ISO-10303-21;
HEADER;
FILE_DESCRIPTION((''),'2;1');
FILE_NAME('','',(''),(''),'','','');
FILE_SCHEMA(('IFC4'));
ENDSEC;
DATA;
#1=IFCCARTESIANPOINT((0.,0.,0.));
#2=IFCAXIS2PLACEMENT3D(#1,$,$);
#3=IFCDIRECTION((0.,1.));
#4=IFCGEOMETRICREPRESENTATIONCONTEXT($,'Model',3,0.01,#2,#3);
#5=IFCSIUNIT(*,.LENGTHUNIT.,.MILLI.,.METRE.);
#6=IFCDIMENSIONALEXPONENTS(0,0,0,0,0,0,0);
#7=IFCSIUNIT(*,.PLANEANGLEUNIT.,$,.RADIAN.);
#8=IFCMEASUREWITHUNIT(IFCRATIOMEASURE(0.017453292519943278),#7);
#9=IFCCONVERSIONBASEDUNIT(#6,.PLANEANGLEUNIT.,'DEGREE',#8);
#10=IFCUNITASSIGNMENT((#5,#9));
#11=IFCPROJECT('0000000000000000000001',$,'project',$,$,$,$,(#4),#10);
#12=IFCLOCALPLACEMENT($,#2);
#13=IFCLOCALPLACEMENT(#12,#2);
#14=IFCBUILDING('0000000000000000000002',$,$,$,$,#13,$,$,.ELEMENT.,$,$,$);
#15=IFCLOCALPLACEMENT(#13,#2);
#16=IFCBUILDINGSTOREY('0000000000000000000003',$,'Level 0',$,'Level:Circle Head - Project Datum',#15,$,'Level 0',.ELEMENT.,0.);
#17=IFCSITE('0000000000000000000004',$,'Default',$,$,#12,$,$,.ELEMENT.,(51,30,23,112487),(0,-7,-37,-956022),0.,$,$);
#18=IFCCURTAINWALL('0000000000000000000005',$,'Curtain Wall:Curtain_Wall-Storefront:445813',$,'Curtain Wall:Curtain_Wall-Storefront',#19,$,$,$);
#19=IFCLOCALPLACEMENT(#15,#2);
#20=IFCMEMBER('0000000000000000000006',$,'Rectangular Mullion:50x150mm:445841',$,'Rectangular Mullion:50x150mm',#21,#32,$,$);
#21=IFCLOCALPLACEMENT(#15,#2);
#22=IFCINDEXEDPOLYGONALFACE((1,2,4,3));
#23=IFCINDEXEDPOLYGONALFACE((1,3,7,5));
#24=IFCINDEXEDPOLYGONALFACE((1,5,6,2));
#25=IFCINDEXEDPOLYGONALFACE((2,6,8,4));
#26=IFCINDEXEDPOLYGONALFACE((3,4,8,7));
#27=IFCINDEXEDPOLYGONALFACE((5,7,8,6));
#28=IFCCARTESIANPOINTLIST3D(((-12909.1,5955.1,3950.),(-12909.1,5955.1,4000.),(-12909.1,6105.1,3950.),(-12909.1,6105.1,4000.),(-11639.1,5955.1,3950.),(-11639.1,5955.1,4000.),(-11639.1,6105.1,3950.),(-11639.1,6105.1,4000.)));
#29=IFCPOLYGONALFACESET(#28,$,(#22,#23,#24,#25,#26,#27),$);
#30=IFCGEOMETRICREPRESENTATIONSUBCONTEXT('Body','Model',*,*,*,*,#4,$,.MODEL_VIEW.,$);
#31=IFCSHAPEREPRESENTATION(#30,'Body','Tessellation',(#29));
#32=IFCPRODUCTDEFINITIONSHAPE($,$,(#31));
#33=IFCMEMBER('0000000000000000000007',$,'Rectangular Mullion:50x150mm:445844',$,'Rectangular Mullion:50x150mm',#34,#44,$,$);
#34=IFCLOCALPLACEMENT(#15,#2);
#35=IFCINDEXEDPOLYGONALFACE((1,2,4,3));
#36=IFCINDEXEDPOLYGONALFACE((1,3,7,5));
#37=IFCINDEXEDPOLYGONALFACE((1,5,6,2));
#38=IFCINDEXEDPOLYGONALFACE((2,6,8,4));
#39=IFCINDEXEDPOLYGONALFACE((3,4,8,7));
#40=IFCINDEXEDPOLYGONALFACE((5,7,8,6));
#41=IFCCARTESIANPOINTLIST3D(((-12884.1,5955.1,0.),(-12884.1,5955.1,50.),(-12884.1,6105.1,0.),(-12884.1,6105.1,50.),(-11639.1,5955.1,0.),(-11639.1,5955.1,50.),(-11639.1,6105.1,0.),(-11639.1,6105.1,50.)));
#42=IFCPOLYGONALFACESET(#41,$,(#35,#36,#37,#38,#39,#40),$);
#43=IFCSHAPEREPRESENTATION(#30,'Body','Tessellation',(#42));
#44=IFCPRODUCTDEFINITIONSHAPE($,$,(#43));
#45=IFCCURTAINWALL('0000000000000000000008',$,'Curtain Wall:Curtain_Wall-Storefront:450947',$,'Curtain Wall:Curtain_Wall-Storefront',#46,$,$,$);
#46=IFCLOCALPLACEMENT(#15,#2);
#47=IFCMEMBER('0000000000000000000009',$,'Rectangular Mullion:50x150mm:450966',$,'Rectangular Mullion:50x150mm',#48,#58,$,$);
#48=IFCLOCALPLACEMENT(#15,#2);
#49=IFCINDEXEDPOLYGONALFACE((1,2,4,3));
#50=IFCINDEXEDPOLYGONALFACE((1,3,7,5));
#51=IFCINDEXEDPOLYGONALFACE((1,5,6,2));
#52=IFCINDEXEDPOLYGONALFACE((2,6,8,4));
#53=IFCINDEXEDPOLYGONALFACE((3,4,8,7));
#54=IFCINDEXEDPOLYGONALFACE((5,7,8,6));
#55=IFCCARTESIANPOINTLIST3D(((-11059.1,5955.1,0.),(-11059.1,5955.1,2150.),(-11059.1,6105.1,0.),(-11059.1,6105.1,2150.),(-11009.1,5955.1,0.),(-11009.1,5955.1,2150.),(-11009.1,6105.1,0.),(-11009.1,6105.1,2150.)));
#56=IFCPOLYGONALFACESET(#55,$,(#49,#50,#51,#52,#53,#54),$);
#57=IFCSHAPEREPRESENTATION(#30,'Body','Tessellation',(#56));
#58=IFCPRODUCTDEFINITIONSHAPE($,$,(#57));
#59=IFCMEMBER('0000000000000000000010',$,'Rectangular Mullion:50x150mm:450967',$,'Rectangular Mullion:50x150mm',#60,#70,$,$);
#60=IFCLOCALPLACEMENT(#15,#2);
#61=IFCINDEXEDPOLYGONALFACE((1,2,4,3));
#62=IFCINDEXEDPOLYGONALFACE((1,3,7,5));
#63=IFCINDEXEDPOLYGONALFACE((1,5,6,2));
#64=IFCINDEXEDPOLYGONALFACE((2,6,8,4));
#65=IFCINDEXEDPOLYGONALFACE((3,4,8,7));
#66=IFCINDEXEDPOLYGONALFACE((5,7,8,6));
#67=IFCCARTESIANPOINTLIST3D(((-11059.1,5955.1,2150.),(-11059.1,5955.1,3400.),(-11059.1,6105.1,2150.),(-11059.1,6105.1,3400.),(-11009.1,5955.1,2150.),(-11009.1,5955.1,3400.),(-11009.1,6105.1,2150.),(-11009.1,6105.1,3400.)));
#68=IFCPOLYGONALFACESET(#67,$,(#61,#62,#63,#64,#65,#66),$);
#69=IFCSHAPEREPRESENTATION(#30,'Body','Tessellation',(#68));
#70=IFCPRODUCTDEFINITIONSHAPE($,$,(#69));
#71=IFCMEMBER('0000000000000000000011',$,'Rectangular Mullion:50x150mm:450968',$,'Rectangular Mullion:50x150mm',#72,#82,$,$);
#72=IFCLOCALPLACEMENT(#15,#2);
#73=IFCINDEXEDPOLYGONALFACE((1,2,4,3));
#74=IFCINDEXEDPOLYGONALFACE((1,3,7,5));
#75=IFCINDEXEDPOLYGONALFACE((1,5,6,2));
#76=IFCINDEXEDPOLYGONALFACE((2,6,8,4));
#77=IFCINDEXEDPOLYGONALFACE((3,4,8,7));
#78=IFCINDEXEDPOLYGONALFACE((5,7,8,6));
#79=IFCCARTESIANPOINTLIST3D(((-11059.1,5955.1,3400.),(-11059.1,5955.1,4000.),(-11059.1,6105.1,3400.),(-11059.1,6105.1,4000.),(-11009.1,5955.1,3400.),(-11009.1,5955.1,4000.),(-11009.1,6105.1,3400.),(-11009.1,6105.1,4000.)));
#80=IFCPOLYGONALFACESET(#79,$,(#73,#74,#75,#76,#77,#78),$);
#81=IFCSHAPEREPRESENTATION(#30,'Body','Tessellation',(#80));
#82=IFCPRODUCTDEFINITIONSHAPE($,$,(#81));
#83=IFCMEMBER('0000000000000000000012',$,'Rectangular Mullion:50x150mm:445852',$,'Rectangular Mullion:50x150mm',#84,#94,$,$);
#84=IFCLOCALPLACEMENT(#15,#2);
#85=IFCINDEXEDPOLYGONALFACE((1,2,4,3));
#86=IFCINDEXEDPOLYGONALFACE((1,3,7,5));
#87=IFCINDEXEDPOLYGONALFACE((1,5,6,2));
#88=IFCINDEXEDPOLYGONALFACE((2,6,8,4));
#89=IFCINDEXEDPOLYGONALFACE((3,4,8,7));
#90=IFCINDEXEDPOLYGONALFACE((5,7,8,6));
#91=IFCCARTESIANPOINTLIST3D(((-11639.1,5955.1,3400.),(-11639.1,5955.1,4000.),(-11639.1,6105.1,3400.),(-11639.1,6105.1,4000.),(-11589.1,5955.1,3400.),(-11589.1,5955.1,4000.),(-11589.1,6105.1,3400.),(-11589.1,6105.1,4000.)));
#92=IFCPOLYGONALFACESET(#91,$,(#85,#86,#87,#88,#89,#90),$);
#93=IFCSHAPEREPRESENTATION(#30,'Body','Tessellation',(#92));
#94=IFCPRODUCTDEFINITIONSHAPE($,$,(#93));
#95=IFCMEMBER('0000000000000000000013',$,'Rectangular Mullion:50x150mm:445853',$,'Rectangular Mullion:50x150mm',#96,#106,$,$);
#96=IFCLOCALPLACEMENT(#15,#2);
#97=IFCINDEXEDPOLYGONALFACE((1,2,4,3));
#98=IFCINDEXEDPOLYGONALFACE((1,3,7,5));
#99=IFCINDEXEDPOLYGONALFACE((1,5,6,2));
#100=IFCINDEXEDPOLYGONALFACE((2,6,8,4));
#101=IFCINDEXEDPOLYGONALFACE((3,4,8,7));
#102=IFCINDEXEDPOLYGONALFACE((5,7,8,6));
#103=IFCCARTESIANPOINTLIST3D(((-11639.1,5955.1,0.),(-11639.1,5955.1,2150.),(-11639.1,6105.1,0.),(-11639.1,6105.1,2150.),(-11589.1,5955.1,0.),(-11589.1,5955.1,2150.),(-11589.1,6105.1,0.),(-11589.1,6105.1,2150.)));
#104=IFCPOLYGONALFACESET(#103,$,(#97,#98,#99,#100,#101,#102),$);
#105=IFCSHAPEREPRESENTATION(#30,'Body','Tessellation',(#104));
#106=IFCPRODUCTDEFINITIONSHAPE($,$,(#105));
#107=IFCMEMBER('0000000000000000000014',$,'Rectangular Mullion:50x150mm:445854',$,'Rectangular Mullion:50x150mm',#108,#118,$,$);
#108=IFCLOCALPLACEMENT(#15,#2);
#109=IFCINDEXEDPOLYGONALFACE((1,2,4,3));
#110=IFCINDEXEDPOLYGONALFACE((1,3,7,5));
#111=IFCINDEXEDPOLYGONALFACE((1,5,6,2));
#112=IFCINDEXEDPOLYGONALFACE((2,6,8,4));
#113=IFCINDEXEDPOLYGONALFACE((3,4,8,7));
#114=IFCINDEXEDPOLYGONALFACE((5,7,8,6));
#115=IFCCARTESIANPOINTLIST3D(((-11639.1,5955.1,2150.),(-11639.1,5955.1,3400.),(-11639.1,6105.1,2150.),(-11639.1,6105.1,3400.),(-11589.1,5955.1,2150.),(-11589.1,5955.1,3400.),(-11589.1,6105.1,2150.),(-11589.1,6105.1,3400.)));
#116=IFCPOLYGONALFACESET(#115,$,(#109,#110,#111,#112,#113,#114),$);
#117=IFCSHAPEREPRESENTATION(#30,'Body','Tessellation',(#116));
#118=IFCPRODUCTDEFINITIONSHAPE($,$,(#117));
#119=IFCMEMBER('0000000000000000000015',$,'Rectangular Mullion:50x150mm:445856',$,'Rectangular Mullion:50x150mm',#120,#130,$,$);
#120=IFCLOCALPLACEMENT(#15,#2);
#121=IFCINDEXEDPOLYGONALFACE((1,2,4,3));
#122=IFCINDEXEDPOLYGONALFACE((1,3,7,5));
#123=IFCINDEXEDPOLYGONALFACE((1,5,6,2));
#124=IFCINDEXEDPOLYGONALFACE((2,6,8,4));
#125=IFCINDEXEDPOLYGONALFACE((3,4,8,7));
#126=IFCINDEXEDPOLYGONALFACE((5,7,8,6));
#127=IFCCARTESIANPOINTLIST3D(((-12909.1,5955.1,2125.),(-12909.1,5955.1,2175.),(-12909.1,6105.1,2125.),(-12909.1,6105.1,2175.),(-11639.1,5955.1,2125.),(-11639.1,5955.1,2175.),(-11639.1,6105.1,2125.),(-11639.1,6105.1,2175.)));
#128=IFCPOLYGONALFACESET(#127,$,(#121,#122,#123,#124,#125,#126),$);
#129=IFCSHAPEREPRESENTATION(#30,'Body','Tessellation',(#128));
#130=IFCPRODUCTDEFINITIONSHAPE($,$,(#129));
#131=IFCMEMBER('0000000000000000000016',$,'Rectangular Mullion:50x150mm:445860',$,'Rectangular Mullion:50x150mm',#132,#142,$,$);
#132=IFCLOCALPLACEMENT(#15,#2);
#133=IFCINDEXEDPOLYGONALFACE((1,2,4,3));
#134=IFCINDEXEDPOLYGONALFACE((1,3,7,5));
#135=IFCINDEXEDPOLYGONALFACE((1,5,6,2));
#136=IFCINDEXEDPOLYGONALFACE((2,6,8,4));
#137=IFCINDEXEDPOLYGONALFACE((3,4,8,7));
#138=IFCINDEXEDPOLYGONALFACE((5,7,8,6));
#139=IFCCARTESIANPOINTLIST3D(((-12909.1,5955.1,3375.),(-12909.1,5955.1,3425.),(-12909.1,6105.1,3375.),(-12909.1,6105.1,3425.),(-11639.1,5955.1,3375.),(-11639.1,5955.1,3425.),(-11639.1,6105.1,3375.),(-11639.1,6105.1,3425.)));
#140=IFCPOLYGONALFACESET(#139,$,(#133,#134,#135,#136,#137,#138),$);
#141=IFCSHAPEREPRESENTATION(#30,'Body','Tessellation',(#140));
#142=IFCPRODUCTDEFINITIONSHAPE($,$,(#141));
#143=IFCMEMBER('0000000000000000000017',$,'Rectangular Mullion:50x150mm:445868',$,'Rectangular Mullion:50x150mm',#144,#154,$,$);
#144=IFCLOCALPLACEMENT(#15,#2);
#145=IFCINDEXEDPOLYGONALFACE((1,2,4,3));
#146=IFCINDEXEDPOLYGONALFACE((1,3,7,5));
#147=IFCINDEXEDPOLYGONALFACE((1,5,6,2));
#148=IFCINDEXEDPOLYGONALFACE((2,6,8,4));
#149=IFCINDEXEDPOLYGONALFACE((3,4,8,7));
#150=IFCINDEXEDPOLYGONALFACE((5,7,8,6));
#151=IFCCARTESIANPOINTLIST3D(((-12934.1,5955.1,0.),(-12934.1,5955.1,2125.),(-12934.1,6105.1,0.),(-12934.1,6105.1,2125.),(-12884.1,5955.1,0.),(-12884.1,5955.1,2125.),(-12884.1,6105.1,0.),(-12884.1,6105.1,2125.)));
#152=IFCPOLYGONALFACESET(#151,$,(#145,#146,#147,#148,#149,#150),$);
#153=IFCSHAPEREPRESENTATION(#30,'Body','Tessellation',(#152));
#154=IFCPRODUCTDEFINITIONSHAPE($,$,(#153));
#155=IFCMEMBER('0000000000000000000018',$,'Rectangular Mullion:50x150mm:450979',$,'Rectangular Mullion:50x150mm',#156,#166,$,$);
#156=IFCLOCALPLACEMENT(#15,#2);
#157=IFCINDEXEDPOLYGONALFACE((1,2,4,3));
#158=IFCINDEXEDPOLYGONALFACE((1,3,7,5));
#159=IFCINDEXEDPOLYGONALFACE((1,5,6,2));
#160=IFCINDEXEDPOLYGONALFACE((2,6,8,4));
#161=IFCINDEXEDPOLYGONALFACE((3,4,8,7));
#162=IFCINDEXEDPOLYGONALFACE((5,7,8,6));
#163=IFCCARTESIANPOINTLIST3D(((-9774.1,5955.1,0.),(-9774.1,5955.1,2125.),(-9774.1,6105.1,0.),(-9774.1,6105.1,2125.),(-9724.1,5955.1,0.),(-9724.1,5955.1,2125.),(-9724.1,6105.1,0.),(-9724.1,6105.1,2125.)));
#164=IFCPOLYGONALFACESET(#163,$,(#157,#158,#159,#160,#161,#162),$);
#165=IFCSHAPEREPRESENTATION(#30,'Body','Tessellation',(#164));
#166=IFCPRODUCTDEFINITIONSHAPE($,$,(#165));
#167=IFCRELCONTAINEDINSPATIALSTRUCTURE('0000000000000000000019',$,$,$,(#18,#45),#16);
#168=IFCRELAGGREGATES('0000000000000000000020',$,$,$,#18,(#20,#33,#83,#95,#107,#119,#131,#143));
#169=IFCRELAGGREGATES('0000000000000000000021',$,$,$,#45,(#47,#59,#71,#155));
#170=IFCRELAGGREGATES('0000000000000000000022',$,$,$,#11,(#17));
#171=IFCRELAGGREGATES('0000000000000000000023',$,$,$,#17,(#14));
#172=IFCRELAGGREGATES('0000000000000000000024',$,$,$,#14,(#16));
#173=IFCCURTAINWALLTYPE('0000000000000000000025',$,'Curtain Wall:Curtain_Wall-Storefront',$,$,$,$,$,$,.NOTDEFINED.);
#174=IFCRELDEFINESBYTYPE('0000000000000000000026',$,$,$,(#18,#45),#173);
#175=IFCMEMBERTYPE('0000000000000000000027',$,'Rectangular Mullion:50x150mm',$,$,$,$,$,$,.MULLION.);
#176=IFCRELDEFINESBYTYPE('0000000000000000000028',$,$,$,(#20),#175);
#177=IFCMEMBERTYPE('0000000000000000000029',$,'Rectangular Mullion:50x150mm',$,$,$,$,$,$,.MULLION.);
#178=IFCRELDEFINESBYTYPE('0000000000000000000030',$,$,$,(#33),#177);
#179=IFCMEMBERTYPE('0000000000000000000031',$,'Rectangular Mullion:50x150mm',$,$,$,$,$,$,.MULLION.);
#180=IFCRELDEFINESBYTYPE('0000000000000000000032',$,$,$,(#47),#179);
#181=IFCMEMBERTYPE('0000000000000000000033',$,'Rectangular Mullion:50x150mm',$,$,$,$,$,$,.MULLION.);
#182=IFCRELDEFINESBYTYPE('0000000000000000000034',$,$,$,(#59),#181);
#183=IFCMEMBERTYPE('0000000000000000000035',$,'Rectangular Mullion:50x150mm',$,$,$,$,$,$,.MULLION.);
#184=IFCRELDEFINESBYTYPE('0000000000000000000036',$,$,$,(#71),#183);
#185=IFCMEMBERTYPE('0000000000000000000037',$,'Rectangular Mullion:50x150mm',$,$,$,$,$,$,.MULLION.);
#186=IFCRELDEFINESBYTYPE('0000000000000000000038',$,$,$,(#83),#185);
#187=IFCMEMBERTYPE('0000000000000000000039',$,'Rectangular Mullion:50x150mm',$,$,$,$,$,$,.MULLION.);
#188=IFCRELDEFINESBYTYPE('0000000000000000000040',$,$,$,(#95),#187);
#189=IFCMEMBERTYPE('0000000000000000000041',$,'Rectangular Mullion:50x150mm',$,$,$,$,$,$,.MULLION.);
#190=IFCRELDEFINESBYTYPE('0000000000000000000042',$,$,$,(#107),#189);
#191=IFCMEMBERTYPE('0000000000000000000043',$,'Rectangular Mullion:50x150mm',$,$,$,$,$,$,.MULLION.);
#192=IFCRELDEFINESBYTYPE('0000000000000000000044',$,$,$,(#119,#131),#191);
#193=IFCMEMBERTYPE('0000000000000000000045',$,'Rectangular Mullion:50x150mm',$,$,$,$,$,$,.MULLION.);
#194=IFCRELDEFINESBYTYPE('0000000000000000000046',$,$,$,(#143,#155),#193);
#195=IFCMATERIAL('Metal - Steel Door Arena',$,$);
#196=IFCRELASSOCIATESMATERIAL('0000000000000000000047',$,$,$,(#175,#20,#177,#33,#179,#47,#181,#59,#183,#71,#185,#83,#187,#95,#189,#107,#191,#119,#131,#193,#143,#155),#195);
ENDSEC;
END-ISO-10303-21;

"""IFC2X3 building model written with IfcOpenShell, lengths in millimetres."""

from ifc_helpers import new_model, entity, si_unit, converted_unit, direction, frame, origin, origin_2d_with_axis, place, context, subcontext, project, spatial, rectangle, extrude, source, transform, mapped, material, type_object, type_shapes, element, aggregate, save


model = new_model("IFC2X3")

# Units and contexts
model_context = context("Model", 3, precision=0.01, world=origin(), true_north=direction((0.0, 1.0)))
body_context = subcontext(model_context, "Body", "Model", "MODEL_VIEW")
ifc_project = project(units=[si_unit("LENGTHUNIT", "METRE", prefix="MILLI"), converted_unit("PLANEANGLEUNIT", "DEGREE", entity("IfcRatioMeasure", 0.017453292519943278), si_unit("PLANEANGLEUNIT", "RADIAN"), dimensions=[0, 0, 0, 0, 0, 0, 0])], contexts=[model_context])

# Site, building, storey
site_placement = place(None, origin())
site = spatial("IfcSite", under=ifc_project, at=site_placement, Name="Default", CompositionType="ELEMENT", RefLatitude=(51, 30, 23, 112487), RefLongitude=(0, -7, -37, -956022), RefElevation=0.0)
building_placement = place(site_placement, origin())
building = spatial("IfcBuilding", under=site, at=building_placement, CompositionType="ELEMENT")
storey_placement = place(building_placement, origin())
storey = spatial("IfcBuildingStorey", under=building, at=storey_placement, Name="Level 0", ObjectType="Level:Circle Head - Project Datum", LongName="Level 0", CompositionType="ELEMENT", Elevation=0.0)

# Curtain walls, members
curtain_wall_type = type_object("IfcCurtainWallType", Name="Curtain Wall:Curtain_Wall-Storefront", PredefinedType="NOTDEFINED")
curtain_wall_1_placement = place(storey_placement, origin())
curtain_wall_1 = element("IfcCurtainWall", 1, at=curtain_wall_1_placement, inside=storey, type_object=curtain_wall_type, Name="Curtain Wall:Curtain_Wall-Storefront:445813", ObjectType="Curtain Wall:Curtain_Wall-Storefront")
ifc_material_1 = material(Name="Metal - Steel Door Arena")
member_type_1 = type_object("IfcMemberType", Name="Rectangular Mullion:50x150mm", PredefinedType="MULLION", material=ifc_material_1)
shared_shape_1 = source(origin(), body_context, "Body", "SweptSolid", [
    extrude(rectangle(XDim=150.0, YDim=50.0, at=origin_2d_with_axis()), frame((-25.0, 0.0, -1270.0), z_axis=(0.0, 0.0, 1.0), x_axis=(0.0, -1.0, 0.0)), (0.0, 0.0, 1.0), 1270.0),
])
type_shapes(member_type_1, [shared_shape_1])
member_1_placement = place(curtain_wall_1_placement, frame((-12909.1, 6030.1, 4000.0), z_axis=(-1.0, 0.0, 0.0), x_axis=(0.0, 0.0, 1.0)))
member_1 = element("IfcMember", 2, at=member_1_placement, type_object=member_type_1, material=ifc_material_1, Name="Rectangular Mullion:50x150mm:445841", ObjectType="Rectangular Mullion:50x150mm", context=body_context, shape_type="MappedRepresentation", body=[
    mapped(shared_shape_1, transform((0.0, 0.0, 0.0), scale=1.0)),
])
member_type_2 = type_object("IfcMemberType", Name="Rectangular Mullion:50x150mm", PredefinedType="MULLION", material=ifc_material_1)
shared_shape_2 = source(origin(), body_context, "Body", "SweptSolid", [
    extrude(rectangle(XDim=150.0, YDim=50.0, at=origin_2d_with_axis()), frame((-25.0, 0.0, -1245.0), z_axis=(0.0, 0.0, 1.0), x_axis=(0.0, -1.0, 0.0)), (0.0, 0.0, 1.0), 1245.0),
])
type_shapes(member_type_2, [shared_shape_2])
member_2_placement = place(curtain_wall_1_placement, frame((-11639.1, 6030.1, 0.0), z_axis=(1.0, 0.0, 0.0), x_axis=(0.0, 0.0, -1.0)))
member_2 = element("IfcMember", 3, at=member_2_placement, type_object=member_type_2, material=ifc_material_1, Name="Rectangular Mullion:50x150mm:445844", ObjectType="Rectangular Mullion:50x150mm", context=body_context, shape_type="MappedRepresentation", body=[
    mapped(shared_shape_2, transform((0.0, 0.0, 0.0), scale=1.0)),
])
curtain_wall_2_placement = place(storey_placement, origin())
curtain_wall_2 = element("IfcCurtainWall", 4, at=curtain_wall_2_placement, inside=storey, type_object=curtain_wall_type, Name="Curtain Wall:Curtain_Wall-Storefront:450947", ObjectType="Curtain Wall:Curtain_Wall-Storefront")
member_type_3 = type_object("IfcMemberType", Name="Rectangular Mullion:50x150mm", PredefinedType="MULLION", material=ifc_material_1)
shared_shape_3 = source(origin(), body_context, "Body", "SweptSolid", [
    extrude(rectangle(XDim=150.0, YDim=50.0, at=origin_2d_with_axis()), frame((-25.0, 0.0, -2150.0), z_axis=(0.0, 0.0, 1.0), x_axis=(0.0, -1.0, 0.0)), (0.0, 0.0, 1.0), 2150.0),
])
type_shapes(member_type_3, [shared_shape_3])
member_3_placement = place(curtain_wall_2_placement, frame((-11059.1, 6030.1, 0.0), z_axis=(0.0, 0.0, -1.0), x_axis=(-1.0, 0.0, 0.0)))
member_3 = element("IfcMember", 5, at=member_3_placement, type_object=member_type_3, material=ifc_material_1, Name="Rectangular Mullion:50x150mm:450966", ObjectType="Rectangular Mullion:50x150mm", context=body_context, shape_type="MappedRepresentation", body=[
    mapped(shared_shape_3, transform((0.0, 0.0, 0.0), scale=1.0)),
])
member_type_4 = type_object("IfcMemberType", Name="Rectangular Mullion:50x150mm", PredefinedType="MULLION", material=ifc_material_1)
shared_shape_4 = source(origin(), body_context, "Body", "SweptSolid", [
    extrude(rectangle(XDim=150.0, YDim=50.0, at=origin_2d_with_axis()), frame((-25.0, 0.0, -1250.0), z_axis=(0.0, 0.0, 1.0), x_axis=(0.0, -1.0, 0.0)), (0.0, 0.0, 1.0), 1250.0),
])
type_shapes(member_type_4, [shared_shape_4])
member_4_placement = place(curtain_wall_2_placement, frame((-11059.1, 6030.1, 2150.0), z_axis=(0.0, 0.0, -1.0), x_axis=(-1.0, 0.0, 0.0)))
member_4 = element("IfcMember", 6, at=member_4_placement, type_object=member_type_4, material=ifc_material_1, Name="Rectangular Mullion:50x150mm:450967", ObjectType="Rectangular Mullion:50x150mm", context=body_context, shape_type="MappedRepresentation", body=[
    mapped(shared_shape_4, transform((0.0, 0.0, 0.0), scale=1.0)),
])
member_type_5 = type_object("IfcMemberType", Name="Rectangular Mullion:50x150mm", PredefinedType="MULLION", material=ifc_material_1)
shared_shape_5 = source(origin(), body_context, "Body", "SweptSolid", [
    extrude(rectangle(XDim=150.0, YDim=50.0, at=origin_2d_with_axis()), frame((-25.0, 0.0, -600.0), z_axis=(0.0, 0.0, 1.0), x_axis=(0.0, -1.0, 0.0)), (0.0, 0.0, 1.0), 600.0),
])
type_shapes(member_type_5, [shared_shape_5])
member_5_placement = place(curtain_wall_2_placement, frame((-11059.1, 6030.1, 3400.0), z_axis=(0.0, 0.0, -1.0), x_axis=(-1.0, 0.0, 0.0)))
member_5 = element("IfcMember", 7, at=member_5_placement, type_object=member_type_5, material=ifc_material_1, Name="Rectangular Mullion:50x150mm:450968", ObjectType="Rectangular Mullion:50x150mm", context=body_context, shape_type="MappedRepresentation", body=[
    mapped(shared_shape_5, transform((0.0, 0.0, 0.0), scale=1.0)),
])

# Members
member_type_6 = type_object("IfcMemberType", Name="Rectangular Mullion:50x150mm", PredefinedType="MULLION", material=ifc_material_1)
shared_shape_6 = source(origin(), body_context, "Body", "SweptSolid", [
    extrude(rectangle(XDim=150.0, YDim=50.0, at=origin_2d_with_axis()), frame((-25.0, 0.0, -600.0), z_axis=(0.0, 0.0, 1.0), x_axis=(0.0, -1.0, 0.0)), (0.0, 0.0, 1.0), 600.0),
])
type_shapes(member_type_6, [shared_shape_6])
member_6_placement = place(curtain_wall_1_placement, frame((-11589.1, 6030.1, 4000.0)))
member_6 = element("IfcMember", 8, at=member_6_placement, type_object=member_type_6, material=ifc_material_1, Name="Rectangular Mullion:50x150mm:445852", ObjectType="Rectangular Mullion:50x150mm", context=body_context, shape_type="MappedRepresentation", body=[
    mapped(shared_shape_6, transform((0.0, 0.0, 0.0), scale=1.0)),
])
member_type_7 = type_object("IfcMemberType", Name="Rectangular Mullion:50x150mm", PredefinedType="MULLION", material=ifc_material_1)
shared_shape_7 = source(origin(), body_context, "Body", "SweptSolid", [
    extrude(rectangle(XDim=150.0, YDim=50.0, at=origin_2d_with_axis()), frame((-25.0, 0.0, -2150.0), z_axis=(0.0, 0.0, 1.0), x_axis=(0.0, -1.0, 0.0)), (0.0, 0.0, 1.0), 2150.0),
])
type_shapes(member_type_7, [shared_shape_7])
member_7_placement = place(curtain_wall_1_placement, frame((-11589.1, 6030.1, 2150.0)))
member_7 = element("IfcMember", 9, at=member_7_placement, type_object=member_type_7, material=ifc_material_1, Name="Rectangular Mullion:50x150mm:445853", ObjectType="Rectangular Mullion:50x150mm", context=body_context, shape_type="MappedRepresentation", body=[
    mapped(shared_shape_7, transform((0.0, 0.0, 0.0), scale=1.0)),
])
member_type_8 = type_object("IfcMemberType", Name="Rectangular Mullion:50x150mm", PredefinedType="MULLION", material=ifc_material_1)
shared_shape_8 = source(origin(), body_context, "Body", "SweptSolid", [
    extrude(rectangle(XDim=150.0, YDim=50.0, at=origin_2d_with_axis()), frame((-25.0, 0.0, -1250.0), z_axis=(0.0, 0.0, 1.0), x_axis=(0.0, -1.0, 0.0)), (0.0, 0.0, 1.0), 1250.0),
])
type_shapes(member_type_8, [shared_shape_8])
member_8_placement = place(curtain_wall_1_placement, frame((-11589.1, 6030.1, 3400.0)))
member_8 = element("IfcMember", 10, at=member_8_placement, type_object=member_type_8, material=ifc_material_1, Name="Rectangular Mullion:50x150mm:445854", ObjectType="Rectangular Mullion:50x150mm", context=body_context, shape_type="MappedRepresentation", body=[
    mapped(shared_shape_8, transform((0.0, 0.0, 0.0), scale=1.0)),
])
member_type_9 = type_object("IfcMemberType", Name="Rectangular Mullion:50x150mm", PredefinedType="MULLION", material=ifc_material_1)
shared_shape_9 = source(origin(), body_context, "Body", "SweptSolid", [
    extrude(rectangle(XDim=150.0, YDim=50.0, at=origin_2d_with_axis()), frame((0.0, 0.0, -1270.0), z_axis=(0.0, 0.0, 1.0), x_axis=(0.0, -1.0, 0.0)), (0.0, 0.0, 1.0), 1270.0),
])
type_shapes(member_type_9, [shared_shape_9])
member_9_placement = place(curtain_wall_1_placement, frame((-12909.1, 6030.1, 2150.0), z_axis=(-1.0, 0.0, 0.0), x_axis=(0.0, 0.0, 1.0)))
member_9 = element("IfcMember", 11, at=member_9_placement, type_object=member_type_9, material=ifc_material_1, Name="Rectangular Mullion:50x150mm:445856", ObjectType="Rectangular Mullion:50x150mm", context=body_context, shape_type="MappedRepresentation", body=[
    mapped(shared_shape_9, transform((0.0, 0.0, 0.0), scale=1.0)),
])
member_10_placement = place(curtain_wall_1_placement, frame((-12909.1, 6030.1, 3400.0), z_axis=(-1.0, 0.0, 0.0), x_axis=(0.0, 0.0, 1.0)))
member_10 = element("IfcMember", 12, at=member_10_placement, type_object=member_type_9, material=ifc_material_1, Name="Rectangular Mullion:50x150mm:445860", ObjectType="Rectangular Mullion:50x150mm", context=body_context, shape_type="MappedRepresentation", body=[
    mapped(shared_shape_9, transform((0.0, 0.0, 0.0), scale=1.0)),
])
member_type_10 = type_object("IfcMemberType", Name="Rectangular Mullion:50x150mm", PredefinedType="MULLION", material=ifc_material_1)
shared_shape_10 = source(origin(), body_context, "Body", "SweptSolid", [
    extrude(rectangle(XDim=150.0, YDim=50.0, at=origin_2d_with_axis()), frame((0.0, 0.0, -2125.0), z_axis=(0.0, 0.0, 1.0), x_axis=(0.0, -1.0, 0.0)), (0.0, 0.0, 1.0), 2125.0),
])
type_shapes(member_type_10, [shared_shape_10])
member_11_placement = place(curtain_wall_1_placement, frame((-12909.1, 6030.1, 0.0), z_axis=(0.0, 0.0, -1.0), x_axis=(-1.0, 0.0, 0.0)))
member_11 = element("IfcMember", 13, at=member_11_placement, type_object=member_type_10, material=ifc_material_1, Name="Rectangular Mullion:50x150mm:445868", ObjectType="Rectangular Mullion:50x150mm", context=body_context, shape_type="MappedRepresentation", body=[
    mapped(shared_shape_10, transform((0.0, 0.0, 0.0), scale=1.0)),
])
member_12_placement = place(curtain_wall_2_placement, frame((-9749.1, 6030.1, 0.0), z_axis=(0.0, 0.0, -1.0), x_axis=(-1.0, 0.0, 0.0)))
member_12 = element("IfcMember", 14, at=member_12_placement, type_object=member_type_10, material=ifc_material_1, Name="Rectangular Mullion:50x150mm:450979", ObjectType="Rectangular Mullion:50x150mm", context=body_context, shape_type="MappedRepresentation", body=[
    mapped(shared_shape_10, transform((0.0, 0.0, 0.0), scale=1.0)),
])

aggregate(curtain_wall_1, [member_1, member_2, member_6, member_7, member_8, member_9, member_10, member_11])
aggregate(curtain_wall_2, [member_3, member_4, member_5, member_12])

save(model, "model.ifc")
